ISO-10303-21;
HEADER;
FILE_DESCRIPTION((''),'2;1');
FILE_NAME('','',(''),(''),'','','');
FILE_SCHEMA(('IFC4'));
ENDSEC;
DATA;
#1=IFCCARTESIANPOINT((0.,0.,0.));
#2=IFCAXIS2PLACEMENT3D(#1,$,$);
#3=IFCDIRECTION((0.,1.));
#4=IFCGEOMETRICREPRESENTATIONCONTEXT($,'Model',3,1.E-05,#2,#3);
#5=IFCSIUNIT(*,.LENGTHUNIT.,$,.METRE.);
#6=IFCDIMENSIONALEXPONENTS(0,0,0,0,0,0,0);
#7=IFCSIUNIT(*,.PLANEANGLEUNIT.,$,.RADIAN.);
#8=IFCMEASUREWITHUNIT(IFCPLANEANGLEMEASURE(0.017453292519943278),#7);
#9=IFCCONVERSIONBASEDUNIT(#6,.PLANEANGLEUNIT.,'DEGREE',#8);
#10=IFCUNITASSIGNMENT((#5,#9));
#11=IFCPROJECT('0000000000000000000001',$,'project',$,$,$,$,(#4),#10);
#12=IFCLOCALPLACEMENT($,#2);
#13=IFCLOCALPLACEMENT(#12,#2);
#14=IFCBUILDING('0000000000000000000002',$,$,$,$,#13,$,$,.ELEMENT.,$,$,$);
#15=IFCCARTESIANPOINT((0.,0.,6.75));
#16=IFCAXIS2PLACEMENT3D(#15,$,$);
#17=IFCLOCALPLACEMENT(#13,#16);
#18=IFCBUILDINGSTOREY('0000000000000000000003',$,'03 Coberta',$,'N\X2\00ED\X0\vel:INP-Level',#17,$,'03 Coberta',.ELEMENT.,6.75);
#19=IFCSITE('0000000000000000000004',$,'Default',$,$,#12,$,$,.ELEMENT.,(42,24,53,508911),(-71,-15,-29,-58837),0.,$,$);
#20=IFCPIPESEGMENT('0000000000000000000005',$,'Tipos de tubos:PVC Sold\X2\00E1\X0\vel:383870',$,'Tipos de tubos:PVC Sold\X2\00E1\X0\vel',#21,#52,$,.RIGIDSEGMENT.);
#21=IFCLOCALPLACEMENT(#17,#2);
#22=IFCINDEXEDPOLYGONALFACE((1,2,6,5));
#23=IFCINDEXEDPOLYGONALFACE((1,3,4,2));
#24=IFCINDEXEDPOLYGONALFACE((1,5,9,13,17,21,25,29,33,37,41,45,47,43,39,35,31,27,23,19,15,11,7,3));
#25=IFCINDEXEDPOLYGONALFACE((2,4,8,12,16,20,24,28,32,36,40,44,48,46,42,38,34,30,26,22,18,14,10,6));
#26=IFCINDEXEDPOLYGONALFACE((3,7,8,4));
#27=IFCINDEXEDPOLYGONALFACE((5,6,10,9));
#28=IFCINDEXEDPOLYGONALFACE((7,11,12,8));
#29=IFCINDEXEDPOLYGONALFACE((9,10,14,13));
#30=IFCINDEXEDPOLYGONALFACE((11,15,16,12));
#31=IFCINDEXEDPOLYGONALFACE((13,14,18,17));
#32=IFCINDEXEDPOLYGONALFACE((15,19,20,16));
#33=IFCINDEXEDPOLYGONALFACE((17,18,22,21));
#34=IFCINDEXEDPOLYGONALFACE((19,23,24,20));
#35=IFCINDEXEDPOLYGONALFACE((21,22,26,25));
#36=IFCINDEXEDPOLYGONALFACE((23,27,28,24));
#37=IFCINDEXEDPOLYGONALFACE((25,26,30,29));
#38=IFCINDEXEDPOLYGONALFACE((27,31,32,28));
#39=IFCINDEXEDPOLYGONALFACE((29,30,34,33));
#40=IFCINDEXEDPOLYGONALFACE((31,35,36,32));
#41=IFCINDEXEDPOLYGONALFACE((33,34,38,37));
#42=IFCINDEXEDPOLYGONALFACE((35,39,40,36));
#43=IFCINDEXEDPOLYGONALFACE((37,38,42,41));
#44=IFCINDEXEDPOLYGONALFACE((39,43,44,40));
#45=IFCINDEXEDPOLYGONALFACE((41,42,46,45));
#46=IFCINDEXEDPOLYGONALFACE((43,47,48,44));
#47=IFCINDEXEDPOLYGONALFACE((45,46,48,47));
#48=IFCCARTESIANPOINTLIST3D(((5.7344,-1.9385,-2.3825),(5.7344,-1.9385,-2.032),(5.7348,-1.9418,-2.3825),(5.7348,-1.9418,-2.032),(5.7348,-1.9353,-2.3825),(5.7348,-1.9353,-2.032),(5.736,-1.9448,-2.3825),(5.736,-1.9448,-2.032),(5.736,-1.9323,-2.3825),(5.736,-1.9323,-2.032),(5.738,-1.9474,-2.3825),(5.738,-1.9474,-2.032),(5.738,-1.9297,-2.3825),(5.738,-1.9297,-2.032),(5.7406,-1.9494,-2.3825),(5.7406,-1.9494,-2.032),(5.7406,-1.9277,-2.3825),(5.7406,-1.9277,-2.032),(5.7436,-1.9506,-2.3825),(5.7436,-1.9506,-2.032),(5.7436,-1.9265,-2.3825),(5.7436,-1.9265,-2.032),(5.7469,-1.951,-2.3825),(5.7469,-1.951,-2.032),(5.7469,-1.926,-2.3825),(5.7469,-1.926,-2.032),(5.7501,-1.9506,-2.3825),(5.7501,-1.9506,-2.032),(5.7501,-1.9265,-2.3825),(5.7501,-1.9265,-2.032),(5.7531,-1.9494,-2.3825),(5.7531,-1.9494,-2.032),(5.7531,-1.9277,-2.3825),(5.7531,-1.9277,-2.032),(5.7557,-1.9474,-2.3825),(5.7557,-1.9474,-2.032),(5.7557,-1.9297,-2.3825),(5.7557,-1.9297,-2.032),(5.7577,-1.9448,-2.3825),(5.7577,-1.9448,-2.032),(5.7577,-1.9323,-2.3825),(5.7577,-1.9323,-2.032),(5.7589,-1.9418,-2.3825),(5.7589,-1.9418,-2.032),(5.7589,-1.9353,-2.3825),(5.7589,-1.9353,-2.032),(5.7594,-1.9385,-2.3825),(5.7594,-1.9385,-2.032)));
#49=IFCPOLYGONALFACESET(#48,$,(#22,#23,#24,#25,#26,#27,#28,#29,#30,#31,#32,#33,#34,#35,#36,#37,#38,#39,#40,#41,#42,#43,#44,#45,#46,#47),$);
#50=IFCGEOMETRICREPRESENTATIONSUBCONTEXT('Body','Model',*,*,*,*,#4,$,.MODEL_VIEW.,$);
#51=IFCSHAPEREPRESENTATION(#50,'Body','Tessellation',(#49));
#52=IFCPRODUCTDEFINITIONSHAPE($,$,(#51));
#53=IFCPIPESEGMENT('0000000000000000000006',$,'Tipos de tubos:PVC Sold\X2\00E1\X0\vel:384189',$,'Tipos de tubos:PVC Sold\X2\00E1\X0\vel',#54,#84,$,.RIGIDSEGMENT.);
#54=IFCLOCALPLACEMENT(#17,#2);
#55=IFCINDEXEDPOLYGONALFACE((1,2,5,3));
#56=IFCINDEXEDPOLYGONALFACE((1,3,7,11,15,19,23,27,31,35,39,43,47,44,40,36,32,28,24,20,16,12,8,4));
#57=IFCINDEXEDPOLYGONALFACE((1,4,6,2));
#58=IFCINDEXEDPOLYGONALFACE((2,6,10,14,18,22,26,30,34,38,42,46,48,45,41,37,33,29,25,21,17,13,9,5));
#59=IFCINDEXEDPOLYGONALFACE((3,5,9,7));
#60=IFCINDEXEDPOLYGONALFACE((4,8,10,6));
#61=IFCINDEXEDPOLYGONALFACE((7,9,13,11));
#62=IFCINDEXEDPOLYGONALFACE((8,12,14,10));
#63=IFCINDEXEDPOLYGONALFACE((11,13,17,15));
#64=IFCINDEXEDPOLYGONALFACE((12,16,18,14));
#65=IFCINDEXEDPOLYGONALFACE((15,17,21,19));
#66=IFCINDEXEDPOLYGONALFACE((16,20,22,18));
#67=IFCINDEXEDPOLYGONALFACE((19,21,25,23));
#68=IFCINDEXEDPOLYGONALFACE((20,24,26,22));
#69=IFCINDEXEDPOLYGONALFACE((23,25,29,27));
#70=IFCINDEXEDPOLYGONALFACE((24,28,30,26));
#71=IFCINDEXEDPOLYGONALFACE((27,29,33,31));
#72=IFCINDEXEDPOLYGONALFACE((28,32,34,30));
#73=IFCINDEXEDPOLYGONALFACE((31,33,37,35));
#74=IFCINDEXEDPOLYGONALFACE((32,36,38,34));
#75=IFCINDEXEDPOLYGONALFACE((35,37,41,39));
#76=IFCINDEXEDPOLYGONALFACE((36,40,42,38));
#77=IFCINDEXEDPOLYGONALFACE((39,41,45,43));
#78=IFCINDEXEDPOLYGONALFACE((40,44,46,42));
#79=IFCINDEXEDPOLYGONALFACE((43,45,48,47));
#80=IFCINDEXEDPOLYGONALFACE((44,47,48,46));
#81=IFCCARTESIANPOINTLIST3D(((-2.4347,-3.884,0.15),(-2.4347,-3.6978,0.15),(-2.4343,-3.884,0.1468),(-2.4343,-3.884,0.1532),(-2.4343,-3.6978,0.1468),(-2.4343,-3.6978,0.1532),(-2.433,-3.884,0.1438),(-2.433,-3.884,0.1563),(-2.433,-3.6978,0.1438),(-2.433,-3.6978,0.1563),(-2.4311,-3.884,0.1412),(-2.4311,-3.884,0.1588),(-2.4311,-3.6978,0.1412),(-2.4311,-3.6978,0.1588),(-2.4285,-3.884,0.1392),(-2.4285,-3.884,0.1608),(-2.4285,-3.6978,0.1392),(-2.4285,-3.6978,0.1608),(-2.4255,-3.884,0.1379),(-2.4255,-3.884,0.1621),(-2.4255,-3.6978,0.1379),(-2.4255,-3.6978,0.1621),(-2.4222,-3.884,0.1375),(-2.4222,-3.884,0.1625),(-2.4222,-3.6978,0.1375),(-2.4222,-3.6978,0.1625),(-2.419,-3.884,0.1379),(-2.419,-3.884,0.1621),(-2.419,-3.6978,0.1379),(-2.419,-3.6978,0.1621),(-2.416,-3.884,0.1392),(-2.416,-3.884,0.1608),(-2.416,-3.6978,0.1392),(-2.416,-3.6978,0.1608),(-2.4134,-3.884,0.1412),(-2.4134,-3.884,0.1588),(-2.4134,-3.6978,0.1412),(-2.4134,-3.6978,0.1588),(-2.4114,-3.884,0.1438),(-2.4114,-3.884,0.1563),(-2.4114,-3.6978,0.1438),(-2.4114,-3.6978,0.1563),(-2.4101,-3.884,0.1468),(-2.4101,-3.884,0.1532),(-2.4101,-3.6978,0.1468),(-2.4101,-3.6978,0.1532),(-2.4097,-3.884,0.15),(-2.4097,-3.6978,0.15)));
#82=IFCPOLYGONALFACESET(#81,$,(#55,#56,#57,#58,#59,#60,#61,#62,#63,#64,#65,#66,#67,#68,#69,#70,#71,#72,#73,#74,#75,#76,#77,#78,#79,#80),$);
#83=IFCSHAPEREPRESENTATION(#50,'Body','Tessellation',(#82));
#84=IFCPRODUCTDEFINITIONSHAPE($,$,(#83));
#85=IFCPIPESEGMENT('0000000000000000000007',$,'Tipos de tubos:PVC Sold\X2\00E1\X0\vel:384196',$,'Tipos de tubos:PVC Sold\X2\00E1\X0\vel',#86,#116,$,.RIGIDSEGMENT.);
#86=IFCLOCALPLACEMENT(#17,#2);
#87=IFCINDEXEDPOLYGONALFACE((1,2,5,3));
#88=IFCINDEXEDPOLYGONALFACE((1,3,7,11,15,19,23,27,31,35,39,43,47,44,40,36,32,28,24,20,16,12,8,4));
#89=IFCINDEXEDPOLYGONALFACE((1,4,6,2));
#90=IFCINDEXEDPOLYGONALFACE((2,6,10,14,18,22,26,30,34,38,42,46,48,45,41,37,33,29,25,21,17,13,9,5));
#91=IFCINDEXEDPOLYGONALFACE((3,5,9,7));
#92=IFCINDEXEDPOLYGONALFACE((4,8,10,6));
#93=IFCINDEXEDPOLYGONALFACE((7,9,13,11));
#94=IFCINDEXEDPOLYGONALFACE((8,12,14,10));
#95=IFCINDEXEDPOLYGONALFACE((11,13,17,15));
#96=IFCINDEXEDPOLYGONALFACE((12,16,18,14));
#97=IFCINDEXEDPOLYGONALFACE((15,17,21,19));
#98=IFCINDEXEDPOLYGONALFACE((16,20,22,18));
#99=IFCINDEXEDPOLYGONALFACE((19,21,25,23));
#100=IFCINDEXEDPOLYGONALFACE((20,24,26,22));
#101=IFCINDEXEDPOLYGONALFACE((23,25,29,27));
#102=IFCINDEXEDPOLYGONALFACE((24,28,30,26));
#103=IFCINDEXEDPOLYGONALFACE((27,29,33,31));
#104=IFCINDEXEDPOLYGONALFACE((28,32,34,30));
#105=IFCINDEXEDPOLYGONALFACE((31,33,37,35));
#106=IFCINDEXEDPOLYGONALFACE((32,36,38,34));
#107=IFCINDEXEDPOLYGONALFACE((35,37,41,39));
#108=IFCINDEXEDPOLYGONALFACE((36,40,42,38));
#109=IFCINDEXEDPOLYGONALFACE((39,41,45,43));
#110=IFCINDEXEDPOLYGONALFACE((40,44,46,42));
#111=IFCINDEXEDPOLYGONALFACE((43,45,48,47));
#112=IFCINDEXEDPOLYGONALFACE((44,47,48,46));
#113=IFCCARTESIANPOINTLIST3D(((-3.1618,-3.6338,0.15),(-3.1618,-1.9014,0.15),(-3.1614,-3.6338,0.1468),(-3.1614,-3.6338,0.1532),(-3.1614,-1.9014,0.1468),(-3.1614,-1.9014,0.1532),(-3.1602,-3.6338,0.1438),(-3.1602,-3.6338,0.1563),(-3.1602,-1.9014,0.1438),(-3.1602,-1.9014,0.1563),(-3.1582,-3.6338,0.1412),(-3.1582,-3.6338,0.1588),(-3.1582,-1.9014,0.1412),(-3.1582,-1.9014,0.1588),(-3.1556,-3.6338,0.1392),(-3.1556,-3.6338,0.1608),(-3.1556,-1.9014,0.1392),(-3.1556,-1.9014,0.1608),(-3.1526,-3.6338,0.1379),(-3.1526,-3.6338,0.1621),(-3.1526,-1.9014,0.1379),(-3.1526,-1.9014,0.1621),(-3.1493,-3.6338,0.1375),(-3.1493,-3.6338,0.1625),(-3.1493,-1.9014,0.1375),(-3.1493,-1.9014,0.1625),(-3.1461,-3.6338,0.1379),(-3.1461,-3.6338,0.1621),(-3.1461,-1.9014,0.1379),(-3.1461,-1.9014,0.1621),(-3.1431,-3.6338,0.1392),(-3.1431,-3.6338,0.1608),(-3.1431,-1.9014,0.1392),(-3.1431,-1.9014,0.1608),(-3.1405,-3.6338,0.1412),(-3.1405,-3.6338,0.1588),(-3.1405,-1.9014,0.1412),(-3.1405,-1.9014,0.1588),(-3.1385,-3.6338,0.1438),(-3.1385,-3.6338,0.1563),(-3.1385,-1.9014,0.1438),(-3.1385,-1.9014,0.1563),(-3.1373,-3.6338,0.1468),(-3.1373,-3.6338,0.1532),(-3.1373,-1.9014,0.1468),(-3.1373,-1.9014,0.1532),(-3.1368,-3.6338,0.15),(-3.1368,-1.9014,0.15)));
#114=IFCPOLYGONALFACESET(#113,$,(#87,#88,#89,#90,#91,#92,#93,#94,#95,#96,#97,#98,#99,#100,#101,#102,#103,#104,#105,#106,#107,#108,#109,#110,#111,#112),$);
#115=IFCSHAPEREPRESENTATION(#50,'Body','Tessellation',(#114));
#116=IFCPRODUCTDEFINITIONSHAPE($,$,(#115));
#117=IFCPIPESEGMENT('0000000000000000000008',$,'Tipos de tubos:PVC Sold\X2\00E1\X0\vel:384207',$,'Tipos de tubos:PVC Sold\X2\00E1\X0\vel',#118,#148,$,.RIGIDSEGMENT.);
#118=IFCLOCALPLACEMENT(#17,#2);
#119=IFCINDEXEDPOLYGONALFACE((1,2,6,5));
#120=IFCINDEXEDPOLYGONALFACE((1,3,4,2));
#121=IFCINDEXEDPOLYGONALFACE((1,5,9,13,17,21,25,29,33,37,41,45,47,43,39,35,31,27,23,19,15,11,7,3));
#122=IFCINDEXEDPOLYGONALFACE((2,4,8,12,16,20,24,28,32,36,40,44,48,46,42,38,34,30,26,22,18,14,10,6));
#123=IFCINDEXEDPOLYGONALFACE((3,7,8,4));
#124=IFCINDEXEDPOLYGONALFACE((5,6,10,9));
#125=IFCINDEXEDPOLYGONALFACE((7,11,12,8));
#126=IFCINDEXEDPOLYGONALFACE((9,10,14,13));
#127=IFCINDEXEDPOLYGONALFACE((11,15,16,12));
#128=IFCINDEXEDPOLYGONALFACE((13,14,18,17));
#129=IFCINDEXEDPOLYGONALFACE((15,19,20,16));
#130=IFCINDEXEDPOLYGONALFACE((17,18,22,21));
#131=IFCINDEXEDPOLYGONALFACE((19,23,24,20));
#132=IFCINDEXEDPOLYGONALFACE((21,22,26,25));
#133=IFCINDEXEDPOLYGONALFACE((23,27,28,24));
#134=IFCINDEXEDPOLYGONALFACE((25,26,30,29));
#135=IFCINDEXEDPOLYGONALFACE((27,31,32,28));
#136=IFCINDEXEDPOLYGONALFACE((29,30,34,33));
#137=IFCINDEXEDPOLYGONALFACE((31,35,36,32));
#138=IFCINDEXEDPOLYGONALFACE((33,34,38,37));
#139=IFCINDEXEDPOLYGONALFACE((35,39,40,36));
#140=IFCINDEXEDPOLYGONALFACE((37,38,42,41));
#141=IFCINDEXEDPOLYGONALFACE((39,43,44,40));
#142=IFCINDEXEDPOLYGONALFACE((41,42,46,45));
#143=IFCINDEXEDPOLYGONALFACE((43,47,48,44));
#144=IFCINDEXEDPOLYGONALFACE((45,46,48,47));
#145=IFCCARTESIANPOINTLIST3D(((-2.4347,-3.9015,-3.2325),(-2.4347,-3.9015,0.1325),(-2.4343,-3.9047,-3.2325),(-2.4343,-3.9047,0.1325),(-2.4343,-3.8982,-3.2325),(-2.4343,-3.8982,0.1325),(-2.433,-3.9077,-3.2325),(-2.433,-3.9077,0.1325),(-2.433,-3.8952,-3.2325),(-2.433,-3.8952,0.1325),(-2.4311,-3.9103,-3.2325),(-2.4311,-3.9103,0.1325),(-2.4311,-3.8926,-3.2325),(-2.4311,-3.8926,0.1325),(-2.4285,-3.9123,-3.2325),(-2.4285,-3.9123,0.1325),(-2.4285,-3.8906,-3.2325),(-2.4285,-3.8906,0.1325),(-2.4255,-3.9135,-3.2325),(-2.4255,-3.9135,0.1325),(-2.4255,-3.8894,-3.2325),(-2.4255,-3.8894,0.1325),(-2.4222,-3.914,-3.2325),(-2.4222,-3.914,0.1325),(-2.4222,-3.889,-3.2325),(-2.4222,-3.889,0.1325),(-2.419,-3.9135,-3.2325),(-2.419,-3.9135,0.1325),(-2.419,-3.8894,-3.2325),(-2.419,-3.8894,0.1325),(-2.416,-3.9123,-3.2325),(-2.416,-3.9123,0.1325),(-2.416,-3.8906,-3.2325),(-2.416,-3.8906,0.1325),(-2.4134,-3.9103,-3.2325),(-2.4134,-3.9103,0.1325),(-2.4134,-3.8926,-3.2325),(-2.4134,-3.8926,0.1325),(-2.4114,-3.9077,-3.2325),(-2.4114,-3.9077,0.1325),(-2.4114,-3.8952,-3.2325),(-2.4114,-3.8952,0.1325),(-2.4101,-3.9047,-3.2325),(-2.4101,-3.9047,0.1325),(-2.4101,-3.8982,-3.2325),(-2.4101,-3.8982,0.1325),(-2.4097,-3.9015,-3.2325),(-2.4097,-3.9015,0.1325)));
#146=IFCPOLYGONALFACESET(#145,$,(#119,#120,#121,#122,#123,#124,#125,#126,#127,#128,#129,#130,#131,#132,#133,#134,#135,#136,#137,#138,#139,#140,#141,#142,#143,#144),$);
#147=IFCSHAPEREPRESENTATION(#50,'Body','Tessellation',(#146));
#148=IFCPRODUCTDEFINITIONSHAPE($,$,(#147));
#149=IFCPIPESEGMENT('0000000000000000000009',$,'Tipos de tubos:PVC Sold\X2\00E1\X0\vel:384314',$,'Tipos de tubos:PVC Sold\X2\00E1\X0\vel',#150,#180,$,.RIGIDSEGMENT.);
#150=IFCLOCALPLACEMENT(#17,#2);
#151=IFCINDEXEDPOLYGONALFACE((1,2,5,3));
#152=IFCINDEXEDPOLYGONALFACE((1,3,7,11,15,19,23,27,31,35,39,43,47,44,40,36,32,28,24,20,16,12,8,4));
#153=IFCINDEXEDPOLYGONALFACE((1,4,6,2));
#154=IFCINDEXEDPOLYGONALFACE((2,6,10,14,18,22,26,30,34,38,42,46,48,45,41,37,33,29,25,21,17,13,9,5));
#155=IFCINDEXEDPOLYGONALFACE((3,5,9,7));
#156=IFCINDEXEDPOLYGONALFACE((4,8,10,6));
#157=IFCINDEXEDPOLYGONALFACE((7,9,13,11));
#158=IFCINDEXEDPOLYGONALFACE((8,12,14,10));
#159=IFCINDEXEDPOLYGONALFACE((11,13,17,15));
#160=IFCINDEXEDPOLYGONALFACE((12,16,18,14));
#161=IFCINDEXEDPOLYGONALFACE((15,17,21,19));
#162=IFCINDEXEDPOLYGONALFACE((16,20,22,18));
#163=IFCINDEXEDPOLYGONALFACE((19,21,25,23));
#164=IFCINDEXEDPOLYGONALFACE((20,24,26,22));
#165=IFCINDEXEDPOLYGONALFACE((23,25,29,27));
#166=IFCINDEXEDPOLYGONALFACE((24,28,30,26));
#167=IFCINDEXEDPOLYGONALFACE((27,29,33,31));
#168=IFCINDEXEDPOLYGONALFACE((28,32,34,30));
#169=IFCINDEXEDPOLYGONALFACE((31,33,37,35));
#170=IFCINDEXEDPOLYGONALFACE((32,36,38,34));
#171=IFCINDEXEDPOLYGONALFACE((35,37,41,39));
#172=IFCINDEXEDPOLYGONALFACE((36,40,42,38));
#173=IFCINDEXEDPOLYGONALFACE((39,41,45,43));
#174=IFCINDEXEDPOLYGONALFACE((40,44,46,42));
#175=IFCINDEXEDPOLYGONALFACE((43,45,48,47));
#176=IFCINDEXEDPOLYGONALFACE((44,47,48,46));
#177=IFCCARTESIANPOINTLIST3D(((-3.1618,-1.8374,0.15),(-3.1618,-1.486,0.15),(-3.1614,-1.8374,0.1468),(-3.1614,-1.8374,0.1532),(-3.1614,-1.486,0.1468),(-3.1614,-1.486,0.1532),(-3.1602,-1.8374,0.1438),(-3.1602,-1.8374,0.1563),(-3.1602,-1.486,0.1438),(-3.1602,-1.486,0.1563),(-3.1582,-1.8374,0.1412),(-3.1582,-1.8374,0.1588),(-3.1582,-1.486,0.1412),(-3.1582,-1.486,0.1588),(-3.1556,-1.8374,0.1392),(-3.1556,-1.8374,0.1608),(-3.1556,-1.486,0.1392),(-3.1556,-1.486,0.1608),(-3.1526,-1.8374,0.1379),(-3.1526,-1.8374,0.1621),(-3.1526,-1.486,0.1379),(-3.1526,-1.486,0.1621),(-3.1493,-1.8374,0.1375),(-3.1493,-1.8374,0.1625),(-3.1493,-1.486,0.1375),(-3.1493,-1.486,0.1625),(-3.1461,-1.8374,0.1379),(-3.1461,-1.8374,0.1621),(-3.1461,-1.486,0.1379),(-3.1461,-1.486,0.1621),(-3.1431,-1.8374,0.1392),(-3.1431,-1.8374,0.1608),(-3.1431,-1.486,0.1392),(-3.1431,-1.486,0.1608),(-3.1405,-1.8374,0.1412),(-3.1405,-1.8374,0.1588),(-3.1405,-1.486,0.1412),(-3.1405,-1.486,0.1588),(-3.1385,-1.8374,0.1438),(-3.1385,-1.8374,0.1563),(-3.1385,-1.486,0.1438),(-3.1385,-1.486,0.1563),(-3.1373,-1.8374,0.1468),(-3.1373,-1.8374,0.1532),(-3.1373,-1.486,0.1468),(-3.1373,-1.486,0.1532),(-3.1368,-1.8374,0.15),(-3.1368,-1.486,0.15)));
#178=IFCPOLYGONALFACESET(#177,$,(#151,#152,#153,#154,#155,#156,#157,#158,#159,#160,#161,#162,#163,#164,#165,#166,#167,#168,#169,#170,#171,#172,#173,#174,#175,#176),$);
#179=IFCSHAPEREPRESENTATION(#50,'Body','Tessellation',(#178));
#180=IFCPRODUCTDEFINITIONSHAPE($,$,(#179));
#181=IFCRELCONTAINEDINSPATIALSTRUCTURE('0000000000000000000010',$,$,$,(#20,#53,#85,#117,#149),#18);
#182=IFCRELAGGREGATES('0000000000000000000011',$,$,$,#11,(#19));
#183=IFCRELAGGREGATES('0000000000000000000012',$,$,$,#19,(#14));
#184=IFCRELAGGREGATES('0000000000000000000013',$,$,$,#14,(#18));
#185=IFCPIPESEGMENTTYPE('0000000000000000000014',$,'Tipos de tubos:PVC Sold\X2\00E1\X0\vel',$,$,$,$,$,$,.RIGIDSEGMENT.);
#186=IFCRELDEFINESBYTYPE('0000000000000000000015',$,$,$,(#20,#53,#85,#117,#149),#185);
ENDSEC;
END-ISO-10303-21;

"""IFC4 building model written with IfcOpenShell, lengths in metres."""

from ifc_helpers import new_model, entity, si_unit, converted_unit, direction, frame, origin, place, context, subcontext, project, spatial, arc, indexed_curve, outline, extrude, type_object, element, save


model = new_model("IFC4")

# Units and contexts
model_context = context("Model", 3, precision=1e-05, world=origin(), true_north=direction((0.0, 1.0)))
body_context = subcontext(model_context, "Body", "Model", "MODEL_VIEW")
ifc_project = project(units=[si_unit("LENGTHUNIT", "METRE"), converted_unit("PLANEANGLEUNIT", "DEGREE", entity("IfcPlaneAngleMeasure", 0.017453292519943278), si_unit("PLANEANGLEUNIT", "RADIAN"), dimensions=[0, 0, 0, 0, 0, 0, 0])], contexts=[model_context])

# Site, building, storey
site_placement = place(None, origin())
site = spatial("IfcSite", under=ifc_project, at=site_placement, Name="Default", CompositionType="ELEMENT", RefLatitude=(42, 24, 53, 508911), RefLongitude=(-71, -15, -29, -58837), RefElevation=0.0)
building_placement = place(site_placement, origin())
building = spatial("IfcBuilding", under=site, at=building_placement, CompositionType="ELEMENT")
storey_placement = place(building_placement, frame((0.0, 0.0, 6.75)))
storey = spatial("IfcBuildingStorey", under=building, at=storey_placement, Name="03 Coberta", ObjectType="Nível:INP-Level", LongName="03 Coberta", CompositionType="ELEMENT", Elevation=6.75)

# Pipe segments
pipe_segment_type = type_object("IfcPipeSegmentType", Name="Tipos de tubos:PVC Soldável", PredefinedType="RIGIDSEGMENT")
pipe_segment_1_placement = place(storey_placement, origin())
element("IfcPipeSegment", 1, at=pipe_segment_1_placement, inside=storey, type_object=pipe_segment_type, Name="Tipos de tubos:PVC Soldável:383870", ObjectType="Tipos de tubos:PVC Soldável", PredefinedType="RIGIDSEGMENT", context=body_context, shape_type="SweptSolid", body=[
    extrude(outline(indexed_curve([(0.0125, 0.0), (0.0088, 0.0088), (0.0, 0.0125), (-0.0088, 0.0088), (-0.0125, 0.0), (-0.0088, -0.0088), (0.0, -0.0125), (0.0088, -0.0088)], segments=[arc(1, 2, 3), arc(3, 4, 5), arc(5, 6, 7), arc(7, 8, 1)], self_intersect=False)), frame((5.7469, -1.9385, -2.3825)), (0.0, 0.0, 1.0), 0.3505),
])
pipe_segment_2_placement = place(storey_placement, origin())
element("IfcPipeSegment", 2, at=pipe_segment_2_placement, inside=storey, type_object=pipe_segment_type, Name="Tipos de tubos:PVC Soldável:384189", ObjectType="Tipos de tubos:PVC Soldável", PredefinedType="RIGIDSEGMENT", context=body_context, shape_type="SweptSolid", body=[
    extrude(outline(indexed_curve([(0.0125, 0.0), (0.0088, 0.0088), (0.0, 0.0125), (-0.0088, 0.0088), (-0.0125, 0.0), (-0.0088, -0.0088), (0.0, -0.0125), (0.0088, -0.0088)], segments=[arc(1, 2, 3), arc(3, 4, 5), arc(5, 6, 7), arc(7, 8, 1)], self_intersect=False)), frame((-2.4222, -3.884, 0.15), z_axis=(0.0, 1.0, 0.0), x_axis=(-1.0, 0.0, 0.0)), (0.0, 0.0, 1.0), 0.1862),
])
pipe_segment_3_placement = place(storey_placement, origin())
element("IfcPipeSegment", 3, at=pipe_segment_3_placement, inside=storey, type_object=pipe_segment_type, Name="Tipos de tubos:PVC Soldável:384196", ObjectType="Tipos de tubos:PVC Soldável", PredefinedType="RIGIDSEGMENT", context=body_context, shape_type="SweptSolid", body=[
    extrude(outline(indexed_curve([(0.0125, 0.0), (0.0088, 0.0088), (0.0, 0.0125), (-0.0088, 0.0088), (-0.0125, 0.0), (-0.0088, -0.0088), (0.0, -0.0125), (0.0088, -0.0088)], segments=[arc(1, 2, 3), arc(3, 4, 5), arc(5, 6, 7), arc(7, 8, 1)], self_intersect=False)), frame((-3.1493, -3.6338, 0.15), z_axis=(0.0, 1.0, 0.0), x_axis=(-1.0, 0.0, 0.0)), (0.0, 0.0, 1.0), 1.7323),
])
pipe_segment_4_placement = place(storey_placement, origin())
element("IfcPipeSegment", 4, at=pipe_segment_4_placement, inside=storey, type_object=pipe_segment_type, Name="Tipos de tubos:PVC Soldável:384207", ObjectType="Tipos de tubos:PVC Soldável", PredefinedType="RIGIDSEGMENT", context=body_context, shape_type="SweptSolid", body=[
    extrude(outline(indexed_curve([(0.0125, 0.0), (0.0088, 0.0088), (0.0, 0.0125), (-0.0088, 0.0088), (-0.0125, 0.0), (-0.0088, -0.0088), (0.0, -0.0125), (0.0088, -0.0088)], segments=[arc(1, 2, 3), arc(3, 4, 5), arc(5, 6, 7), arc(7, 8, 1)], self_intersect=False)), frame((-2.4222, -3.9015, -3.2325)), (0.0, 0.0, 1.0), 3.365),
])
pipe_segment_5_placement = place(storey_placement, origin())
element("IfcPipeSegment", 5, at=pipe_segment_5_placement, inside=storey, type_object=pipe_segment_type, Name="Tipos de tubos:PVC Soldável:384314", ObjectType="Tipos de tubos:PVC Soldável", PredefinedType="RIGIDSEGMENT", context=body_context, shape_type="SweptSolid", body=[
    extrude(outline(indexed_curve([(0.0125, 0.0), (0.0088, 0.0088), (0.0, 0.0125), (-0.0088, 0.0088), (-0.0125, 0.0), (-0.0088, -0.0088), (0.0, -0.0125), (0.0088, -0.0088)], segments=[arc(1, 2, 3), arc(3, 4, 5), arc(5, 6, 7), arc(7, 8, 1)], self_intersect=False)), frame((-3.1493, -1.8374, 0.15), z_axis=(0.0, 1.0, 0.0), x_axis=(-1.0, 0.0, 0.0)), (0.0, 0.0, 1.0), 0.3514),
])

save(model, "model.ifc")
